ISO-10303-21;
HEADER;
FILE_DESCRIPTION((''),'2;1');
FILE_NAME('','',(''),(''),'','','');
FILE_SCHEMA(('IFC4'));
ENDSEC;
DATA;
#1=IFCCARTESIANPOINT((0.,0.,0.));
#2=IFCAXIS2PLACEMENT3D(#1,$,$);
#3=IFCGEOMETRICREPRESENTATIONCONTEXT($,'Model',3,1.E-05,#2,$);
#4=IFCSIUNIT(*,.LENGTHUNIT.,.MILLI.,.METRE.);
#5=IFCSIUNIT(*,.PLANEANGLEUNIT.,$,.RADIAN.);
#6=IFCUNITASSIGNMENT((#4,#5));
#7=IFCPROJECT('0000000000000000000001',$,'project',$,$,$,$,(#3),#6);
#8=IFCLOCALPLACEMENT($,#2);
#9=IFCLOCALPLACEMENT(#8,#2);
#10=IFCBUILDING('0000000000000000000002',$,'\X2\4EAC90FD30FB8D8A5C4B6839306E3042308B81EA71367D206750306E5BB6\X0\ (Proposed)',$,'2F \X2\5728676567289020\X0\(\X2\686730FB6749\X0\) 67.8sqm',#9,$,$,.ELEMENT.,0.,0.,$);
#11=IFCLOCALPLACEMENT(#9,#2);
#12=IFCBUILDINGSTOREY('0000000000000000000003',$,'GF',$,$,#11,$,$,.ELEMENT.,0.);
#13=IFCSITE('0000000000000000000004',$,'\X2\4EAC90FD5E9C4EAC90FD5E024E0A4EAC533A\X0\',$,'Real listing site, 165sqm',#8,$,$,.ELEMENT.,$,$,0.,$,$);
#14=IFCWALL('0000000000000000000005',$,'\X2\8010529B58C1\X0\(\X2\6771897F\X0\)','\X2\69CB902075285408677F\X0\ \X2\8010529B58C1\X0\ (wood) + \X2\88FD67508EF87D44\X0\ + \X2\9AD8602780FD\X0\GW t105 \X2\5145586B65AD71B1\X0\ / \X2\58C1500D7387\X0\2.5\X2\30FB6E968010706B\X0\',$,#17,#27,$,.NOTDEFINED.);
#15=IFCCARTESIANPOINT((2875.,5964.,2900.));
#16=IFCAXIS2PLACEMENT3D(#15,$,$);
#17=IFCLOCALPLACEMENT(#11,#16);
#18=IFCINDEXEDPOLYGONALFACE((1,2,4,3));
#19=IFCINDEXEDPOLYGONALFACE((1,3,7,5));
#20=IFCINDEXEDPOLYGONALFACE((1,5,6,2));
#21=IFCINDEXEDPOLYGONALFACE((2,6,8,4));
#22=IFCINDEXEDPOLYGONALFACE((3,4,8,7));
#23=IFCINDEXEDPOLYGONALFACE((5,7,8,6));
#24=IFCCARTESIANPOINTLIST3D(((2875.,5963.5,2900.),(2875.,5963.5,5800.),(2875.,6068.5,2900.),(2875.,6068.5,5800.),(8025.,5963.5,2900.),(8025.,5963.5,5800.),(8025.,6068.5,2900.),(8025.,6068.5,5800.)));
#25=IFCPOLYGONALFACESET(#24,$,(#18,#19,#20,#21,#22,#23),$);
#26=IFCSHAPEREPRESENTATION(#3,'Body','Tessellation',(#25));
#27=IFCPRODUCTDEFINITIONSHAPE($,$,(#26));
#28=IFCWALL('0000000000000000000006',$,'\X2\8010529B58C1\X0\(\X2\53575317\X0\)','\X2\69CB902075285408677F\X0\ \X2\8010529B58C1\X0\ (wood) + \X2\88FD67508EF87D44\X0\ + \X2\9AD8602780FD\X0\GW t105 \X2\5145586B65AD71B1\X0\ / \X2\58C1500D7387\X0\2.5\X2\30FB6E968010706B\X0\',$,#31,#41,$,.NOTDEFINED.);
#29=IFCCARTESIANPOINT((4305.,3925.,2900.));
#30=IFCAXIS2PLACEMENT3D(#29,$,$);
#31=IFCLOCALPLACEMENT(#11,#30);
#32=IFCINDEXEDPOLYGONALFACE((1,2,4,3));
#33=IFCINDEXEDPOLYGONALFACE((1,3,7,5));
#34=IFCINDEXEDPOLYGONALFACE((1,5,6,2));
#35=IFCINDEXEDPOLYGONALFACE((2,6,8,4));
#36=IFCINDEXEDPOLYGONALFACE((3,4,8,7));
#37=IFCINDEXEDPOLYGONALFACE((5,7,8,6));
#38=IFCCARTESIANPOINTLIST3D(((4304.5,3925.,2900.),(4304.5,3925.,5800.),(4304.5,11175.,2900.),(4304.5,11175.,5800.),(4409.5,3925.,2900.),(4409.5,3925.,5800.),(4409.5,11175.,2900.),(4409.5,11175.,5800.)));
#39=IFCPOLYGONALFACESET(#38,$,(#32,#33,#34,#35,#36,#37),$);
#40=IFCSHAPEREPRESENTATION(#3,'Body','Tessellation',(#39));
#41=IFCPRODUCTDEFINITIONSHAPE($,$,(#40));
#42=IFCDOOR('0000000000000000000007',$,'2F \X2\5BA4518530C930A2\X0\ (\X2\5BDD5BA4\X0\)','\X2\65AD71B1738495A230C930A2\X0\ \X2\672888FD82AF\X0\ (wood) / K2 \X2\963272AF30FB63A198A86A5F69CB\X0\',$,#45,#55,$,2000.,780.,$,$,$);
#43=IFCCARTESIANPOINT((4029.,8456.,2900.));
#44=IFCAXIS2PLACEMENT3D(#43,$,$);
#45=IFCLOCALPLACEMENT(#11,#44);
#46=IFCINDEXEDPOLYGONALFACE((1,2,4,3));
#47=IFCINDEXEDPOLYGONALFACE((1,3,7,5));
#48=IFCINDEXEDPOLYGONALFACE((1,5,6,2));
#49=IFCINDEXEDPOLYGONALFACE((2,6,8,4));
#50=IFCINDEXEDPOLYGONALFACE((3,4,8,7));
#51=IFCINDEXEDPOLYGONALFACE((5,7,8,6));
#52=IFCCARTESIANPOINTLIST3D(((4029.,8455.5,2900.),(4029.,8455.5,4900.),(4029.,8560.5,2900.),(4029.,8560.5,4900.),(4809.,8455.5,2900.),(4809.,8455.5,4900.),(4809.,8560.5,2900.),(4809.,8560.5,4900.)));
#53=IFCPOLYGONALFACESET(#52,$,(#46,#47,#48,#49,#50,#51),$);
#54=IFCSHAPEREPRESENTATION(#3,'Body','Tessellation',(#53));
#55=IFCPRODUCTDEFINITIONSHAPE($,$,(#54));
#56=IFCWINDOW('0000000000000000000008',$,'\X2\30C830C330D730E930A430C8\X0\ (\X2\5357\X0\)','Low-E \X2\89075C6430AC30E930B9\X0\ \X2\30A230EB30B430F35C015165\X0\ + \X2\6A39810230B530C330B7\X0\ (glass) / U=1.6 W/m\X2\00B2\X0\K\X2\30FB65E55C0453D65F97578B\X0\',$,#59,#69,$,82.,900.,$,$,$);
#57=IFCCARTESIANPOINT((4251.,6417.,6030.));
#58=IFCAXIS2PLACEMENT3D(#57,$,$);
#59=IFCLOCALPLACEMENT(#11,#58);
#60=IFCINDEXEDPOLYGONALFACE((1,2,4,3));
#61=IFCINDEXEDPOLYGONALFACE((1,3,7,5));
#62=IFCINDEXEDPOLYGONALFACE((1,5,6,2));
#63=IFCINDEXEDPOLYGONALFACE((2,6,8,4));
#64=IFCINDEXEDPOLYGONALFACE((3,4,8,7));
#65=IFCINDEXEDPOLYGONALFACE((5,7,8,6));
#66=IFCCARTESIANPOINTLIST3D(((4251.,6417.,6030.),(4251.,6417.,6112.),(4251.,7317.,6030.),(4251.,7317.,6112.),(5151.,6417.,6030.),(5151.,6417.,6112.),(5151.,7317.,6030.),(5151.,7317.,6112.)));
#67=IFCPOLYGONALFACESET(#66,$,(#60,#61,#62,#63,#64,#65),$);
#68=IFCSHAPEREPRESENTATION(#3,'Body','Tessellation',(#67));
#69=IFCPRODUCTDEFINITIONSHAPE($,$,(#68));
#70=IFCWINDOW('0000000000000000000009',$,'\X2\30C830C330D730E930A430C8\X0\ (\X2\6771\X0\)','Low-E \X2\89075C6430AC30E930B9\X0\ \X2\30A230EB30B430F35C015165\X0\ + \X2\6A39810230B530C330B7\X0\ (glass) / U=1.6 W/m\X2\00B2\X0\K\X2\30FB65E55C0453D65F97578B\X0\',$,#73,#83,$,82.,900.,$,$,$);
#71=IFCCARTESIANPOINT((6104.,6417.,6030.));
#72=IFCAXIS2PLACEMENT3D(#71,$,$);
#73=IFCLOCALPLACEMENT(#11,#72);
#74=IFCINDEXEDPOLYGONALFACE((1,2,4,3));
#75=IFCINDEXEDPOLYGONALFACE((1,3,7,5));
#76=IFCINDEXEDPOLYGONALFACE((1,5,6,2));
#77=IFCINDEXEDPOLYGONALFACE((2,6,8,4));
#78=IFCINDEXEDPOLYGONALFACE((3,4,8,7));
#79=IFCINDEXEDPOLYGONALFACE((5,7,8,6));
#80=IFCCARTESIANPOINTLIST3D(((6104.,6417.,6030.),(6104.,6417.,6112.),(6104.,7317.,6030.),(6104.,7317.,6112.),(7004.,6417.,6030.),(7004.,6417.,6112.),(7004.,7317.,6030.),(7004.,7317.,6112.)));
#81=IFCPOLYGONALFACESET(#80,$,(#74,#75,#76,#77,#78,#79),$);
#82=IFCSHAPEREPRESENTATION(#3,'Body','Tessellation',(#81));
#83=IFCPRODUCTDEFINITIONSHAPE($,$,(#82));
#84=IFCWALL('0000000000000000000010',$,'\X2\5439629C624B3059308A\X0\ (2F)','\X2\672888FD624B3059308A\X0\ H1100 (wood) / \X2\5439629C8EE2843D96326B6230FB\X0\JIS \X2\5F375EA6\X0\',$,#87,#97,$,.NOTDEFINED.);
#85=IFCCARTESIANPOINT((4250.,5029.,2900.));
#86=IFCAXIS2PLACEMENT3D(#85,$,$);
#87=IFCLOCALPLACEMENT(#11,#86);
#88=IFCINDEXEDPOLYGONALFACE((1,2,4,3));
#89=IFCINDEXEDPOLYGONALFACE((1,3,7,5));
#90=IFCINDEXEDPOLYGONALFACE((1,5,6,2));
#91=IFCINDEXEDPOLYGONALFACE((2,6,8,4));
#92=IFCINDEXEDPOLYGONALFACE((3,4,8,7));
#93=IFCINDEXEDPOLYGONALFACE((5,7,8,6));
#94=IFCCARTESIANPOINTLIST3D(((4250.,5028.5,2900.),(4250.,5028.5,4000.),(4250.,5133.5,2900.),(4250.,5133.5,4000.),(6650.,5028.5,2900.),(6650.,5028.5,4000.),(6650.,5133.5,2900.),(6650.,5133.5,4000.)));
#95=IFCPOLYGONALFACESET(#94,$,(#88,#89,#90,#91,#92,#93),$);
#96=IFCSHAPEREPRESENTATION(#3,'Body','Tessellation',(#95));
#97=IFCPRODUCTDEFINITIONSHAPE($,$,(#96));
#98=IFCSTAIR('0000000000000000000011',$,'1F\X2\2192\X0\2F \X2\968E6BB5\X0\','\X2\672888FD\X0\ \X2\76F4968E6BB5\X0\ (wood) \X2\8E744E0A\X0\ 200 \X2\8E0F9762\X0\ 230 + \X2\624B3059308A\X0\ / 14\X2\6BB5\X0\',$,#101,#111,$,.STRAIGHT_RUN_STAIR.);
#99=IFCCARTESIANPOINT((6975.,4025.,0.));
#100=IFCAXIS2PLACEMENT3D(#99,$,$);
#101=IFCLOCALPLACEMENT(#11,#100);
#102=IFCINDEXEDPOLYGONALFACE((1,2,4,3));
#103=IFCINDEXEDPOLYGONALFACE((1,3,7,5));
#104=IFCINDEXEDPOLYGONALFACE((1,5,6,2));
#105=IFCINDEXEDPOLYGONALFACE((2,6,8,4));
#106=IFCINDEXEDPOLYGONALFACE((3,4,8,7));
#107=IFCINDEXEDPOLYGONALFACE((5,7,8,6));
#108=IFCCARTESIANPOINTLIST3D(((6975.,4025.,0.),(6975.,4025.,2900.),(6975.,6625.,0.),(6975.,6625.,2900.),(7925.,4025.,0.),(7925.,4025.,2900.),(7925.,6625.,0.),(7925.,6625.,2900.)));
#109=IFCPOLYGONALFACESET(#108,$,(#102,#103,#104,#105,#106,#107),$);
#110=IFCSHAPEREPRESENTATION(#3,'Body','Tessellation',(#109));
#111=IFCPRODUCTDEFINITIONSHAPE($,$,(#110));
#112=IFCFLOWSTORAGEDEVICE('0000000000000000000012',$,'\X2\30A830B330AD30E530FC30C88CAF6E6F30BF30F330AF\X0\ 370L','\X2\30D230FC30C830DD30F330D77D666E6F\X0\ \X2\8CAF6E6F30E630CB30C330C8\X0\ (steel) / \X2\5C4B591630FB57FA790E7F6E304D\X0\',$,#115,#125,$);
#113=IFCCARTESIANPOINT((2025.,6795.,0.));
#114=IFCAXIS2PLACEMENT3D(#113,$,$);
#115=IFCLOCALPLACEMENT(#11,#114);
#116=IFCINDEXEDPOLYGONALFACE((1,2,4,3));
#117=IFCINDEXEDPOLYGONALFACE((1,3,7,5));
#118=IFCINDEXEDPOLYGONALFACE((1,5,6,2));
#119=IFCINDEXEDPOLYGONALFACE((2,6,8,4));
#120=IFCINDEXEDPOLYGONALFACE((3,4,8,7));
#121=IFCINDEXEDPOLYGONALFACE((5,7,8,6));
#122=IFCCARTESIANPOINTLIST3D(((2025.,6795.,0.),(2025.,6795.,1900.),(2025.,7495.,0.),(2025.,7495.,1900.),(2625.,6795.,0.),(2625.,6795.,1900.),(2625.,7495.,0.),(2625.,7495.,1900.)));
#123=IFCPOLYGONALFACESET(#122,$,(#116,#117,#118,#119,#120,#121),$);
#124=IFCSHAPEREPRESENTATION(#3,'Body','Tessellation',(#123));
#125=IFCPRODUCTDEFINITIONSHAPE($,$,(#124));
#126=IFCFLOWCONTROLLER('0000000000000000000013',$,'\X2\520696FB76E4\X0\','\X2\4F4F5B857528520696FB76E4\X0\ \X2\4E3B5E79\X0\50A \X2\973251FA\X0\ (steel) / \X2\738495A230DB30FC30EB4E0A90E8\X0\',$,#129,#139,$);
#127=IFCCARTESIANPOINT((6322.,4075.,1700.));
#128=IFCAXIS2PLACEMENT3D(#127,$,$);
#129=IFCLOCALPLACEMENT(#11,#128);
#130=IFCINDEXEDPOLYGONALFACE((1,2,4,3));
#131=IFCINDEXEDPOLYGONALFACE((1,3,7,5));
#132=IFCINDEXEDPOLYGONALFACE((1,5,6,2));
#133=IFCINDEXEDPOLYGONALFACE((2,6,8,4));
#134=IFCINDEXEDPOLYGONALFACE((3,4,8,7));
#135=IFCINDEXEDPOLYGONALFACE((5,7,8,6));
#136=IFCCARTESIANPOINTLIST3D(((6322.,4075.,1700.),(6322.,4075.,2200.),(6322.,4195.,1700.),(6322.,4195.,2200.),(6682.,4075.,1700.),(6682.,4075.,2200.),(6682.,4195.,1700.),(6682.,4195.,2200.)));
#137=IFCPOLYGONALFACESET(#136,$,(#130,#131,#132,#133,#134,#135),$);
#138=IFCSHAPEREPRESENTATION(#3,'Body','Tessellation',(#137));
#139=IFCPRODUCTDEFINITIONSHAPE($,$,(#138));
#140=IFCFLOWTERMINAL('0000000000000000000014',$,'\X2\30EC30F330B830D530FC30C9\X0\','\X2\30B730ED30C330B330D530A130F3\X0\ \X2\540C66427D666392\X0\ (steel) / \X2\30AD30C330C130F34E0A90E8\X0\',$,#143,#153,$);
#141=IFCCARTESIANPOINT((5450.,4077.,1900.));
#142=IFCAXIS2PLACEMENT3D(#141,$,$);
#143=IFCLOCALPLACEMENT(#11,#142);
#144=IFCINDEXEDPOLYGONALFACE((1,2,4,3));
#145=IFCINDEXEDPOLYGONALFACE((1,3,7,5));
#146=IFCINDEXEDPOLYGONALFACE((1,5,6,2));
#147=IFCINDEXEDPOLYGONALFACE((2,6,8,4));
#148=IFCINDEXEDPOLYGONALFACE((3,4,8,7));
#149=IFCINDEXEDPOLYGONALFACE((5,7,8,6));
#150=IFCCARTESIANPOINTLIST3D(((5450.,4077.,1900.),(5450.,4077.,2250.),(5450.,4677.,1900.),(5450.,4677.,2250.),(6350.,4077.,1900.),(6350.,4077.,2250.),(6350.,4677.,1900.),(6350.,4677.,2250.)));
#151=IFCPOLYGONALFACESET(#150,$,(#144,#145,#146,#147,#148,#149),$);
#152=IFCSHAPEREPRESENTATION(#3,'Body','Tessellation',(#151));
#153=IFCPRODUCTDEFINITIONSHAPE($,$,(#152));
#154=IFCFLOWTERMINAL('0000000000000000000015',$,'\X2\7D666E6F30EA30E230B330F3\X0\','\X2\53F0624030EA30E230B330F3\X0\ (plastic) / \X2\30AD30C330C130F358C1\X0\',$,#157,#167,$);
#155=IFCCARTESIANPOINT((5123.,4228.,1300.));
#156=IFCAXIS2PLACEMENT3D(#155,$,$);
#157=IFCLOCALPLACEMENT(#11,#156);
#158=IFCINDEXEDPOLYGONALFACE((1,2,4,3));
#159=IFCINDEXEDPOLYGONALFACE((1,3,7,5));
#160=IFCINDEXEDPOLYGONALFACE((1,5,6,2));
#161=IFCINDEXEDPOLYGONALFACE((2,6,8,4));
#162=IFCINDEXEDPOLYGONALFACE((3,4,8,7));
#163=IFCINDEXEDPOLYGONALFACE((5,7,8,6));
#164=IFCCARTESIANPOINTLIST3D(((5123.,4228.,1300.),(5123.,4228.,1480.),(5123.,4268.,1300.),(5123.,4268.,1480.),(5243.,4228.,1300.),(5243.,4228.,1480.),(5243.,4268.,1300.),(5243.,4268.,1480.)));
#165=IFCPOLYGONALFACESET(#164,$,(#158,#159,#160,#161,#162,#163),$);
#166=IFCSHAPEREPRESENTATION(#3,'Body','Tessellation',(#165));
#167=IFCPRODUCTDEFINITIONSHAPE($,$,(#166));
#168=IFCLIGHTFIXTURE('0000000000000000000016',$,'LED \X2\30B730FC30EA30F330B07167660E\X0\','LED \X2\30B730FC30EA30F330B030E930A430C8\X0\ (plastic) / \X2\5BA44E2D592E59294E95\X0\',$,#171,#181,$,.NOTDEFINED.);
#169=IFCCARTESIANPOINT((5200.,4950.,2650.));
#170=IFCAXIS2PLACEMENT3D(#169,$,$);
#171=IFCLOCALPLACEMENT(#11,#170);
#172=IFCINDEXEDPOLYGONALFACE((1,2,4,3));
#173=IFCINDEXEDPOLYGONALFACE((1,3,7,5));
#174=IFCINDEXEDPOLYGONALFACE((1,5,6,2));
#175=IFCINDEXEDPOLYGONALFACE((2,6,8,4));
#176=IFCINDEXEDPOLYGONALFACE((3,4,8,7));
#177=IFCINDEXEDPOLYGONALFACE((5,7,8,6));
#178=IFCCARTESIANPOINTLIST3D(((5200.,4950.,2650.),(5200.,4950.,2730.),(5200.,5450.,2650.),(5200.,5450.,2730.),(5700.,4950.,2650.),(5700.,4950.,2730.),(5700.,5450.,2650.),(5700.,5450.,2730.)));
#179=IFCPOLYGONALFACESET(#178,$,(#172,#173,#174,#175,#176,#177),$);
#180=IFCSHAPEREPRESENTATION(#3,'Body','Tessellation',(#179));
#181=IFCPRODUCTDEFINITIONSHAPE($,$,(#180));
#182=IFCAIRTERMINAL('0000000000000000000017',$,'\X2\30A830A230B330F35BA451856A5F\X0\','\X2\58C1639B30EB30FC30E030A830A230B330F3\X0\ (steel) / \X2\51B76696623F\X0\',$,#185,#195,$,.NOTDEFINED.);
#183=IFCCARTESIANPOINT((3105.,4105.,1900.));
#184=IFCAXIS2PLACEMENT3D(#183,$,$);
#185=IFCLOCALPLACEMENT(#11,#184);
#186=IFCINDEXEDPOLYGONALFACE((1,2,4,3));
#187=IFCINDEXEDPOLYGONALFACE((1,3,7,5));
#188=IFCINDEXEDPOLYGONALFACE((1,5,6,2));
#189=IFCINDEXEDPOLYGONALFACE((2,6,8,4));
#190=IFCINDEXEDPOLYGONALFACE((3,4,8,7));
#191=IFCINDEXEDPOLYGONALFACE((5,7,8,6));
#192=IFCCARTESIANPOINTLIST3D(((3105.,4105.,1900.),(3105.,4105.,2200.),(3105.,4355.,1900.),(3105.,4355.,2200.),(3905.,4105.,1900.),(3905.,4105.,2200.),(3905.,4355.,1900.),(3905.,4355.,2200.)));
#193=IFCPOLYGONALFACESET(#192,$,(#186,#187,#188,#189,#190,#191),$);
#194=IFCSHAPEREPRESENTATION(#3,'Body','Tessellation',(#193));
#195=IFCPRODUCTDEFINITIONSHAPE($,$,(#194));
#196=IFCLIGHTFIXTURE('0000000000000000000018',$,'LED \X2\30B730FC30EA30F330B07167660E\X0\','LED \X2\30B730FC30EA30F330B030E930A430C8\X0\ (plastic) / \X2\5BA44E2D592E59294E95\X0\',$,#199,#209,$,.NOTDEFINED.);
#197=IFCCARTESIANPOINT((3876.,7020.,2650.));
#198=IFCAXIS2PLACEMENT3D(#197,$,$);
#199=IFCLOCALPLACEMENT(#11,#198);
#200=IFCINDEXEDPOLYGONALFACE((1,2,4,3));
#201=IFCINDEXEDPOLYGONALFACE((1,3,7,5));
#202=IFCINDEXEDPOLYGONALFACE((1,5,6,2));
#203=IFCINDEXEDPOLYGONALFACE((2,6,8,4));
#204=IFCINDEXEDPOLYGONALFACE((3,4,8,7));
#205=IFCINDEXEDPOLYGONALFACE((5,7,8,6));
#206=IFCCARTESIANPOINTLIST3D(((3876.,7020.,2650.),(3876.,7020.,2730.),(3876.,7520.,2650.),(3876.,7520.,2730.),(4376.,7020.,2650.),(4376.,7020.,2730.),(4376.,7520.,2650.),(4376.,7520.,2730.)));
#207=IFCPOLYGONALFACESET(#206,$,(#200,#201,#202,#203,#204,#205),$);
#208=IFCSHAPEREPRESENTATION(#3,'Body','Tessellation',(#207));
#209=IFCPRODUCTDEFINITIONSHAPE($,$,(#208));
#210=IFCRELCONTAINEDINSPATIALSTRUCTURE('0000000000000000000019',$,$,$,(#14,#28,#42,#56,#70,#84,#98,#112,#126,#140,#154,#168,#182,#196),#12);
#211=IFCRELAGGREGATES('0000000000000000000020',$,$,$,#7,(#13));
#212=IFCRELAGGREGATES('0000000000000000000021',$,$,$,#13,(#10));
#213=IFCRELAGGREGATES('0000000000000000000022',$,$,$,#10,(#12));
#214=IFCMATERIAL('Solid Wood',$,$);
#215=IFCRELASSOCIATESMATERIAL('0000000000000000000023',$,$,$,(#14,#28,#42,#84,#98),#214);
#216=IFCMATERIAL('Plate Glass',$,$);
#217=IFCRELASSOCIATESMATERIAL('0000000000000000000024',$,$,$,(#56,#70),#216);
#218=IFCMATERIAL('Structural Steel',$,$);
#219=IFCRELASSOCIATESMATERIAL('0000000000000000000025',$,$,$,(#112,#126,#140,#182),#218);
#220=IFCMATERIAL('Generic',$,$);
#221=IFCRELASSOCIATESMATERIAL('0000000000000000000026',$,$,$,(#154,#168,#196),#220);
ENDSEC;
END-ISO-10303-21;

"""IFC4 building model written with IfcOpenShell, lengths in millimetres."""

from ifc_helpers import new_model, si_unit, frame, frame_2d, origin, place, context, project, spatial, rectangle, extrude, material, element, fill, save


model = new_model("IFC4")

# Units and contexts
model_context = context("Model", 3, precision=1e-05, world=origin())
ifc_project = project(units=[si_unit("LENGTHUNIT", "METRE", prefix="MILLI"), si_unit("PLANEANGLEUNIT", "RADIAN")], contexts=[model_context])

# Site, building, storey
site_placement = place(None, origin())
site = spatial("IfcSite", under=ifc_project, at=site_placement, Name="京都府京都市上京区", ObjectType="Real listing site, 165sqm", CompositionType="ELEMENT", RefElevation=0.0)
building_placement = place(site_placement, origin())
building = spatial("IfcBuilding", under=site, at=building_placement, Name="京都・越屋根のある自然素材の家 (Proposed)", ObjectType="2F 在来木造(桧・杉) 67.8sqm", CompositionType="ELEMENT", ElevationOfRefHeight=0.0, ElevationOfTerrain=0.0)
storey_placement = place(building_placement, origin())
storey = spatial("IfcBuildingStorey", under=building, at=storey_placement, Name="GF", CompositionType="ELEMENT", Elevation=0.0)

# Shared definitions
ifc_material_1 = material(Name="Solid Wood")

# Wall
wall_1_placement = place(storey_placement, frame((2875.0, 5964.0, 2900.0)))
element("IfcWall", 1, at=wall_1_placement, inside=storey, material=ifc_material_1, Name="耐力壁(東西)", Description="構造用合板 耐力壁 (wood) + 製材軸組 + 高性能GW t105 充填断熱 / 壁倍率2.5・準耐火", PredefinedType="NOTDEFINED", context=model_context, shape_type="SweptSolid", body=[
    extrude(rectangle(XDim=5150.0, YDim=105.0, at=frame_2d((2575.0, 52.0))), frame((2875.0, 5964.0, 2900.0)), (0.0, 0.0, 1.0), 2900.0),
])

# Wall, opening, door
wall_2_placement = place(storey_placement, frame((4305.0, 3925.0, 2900.0)))
wall_2 = element("IfcWall", 2, at=wall_2_placement, inside=storey, material=ifc_material_1, Name="耐力壁(南北)", Description="構造用合板 耐力壁 (wood) + 製材軸組 + 高性能GW t105 充填断熱 / 壁倍率2.5・準耐火", PredefinedType="NOTDEFINED", context=model_context, shape_type="SweptSolid", body=[
    extrude(rectangle(XDim=105.0, YDim=7250.0, at=frame_2d((52.0, 3625.0))), frame((4305.0, 3925.0, 2900.0)), (0.0, 0.0, 1.0), 2900.0),
])
opening_placement = place(storey_placement, frame((4029.0, 8456.0, 2900.0)))
opening = element("IfcOpeningElement", 3, at=opening_placement, cuts=wall_2, PredefinedType="NOTDEFINED", context=model_context, shape_type="SweptSolid", body=[
    extrude(rectangle(XDim=780.0, YDim=105.0, at=frame_2d((390.0, 52.0))), frame((4029.0, 8456.0, 2900.0)), (0.0, 0.0, 1.0), 2000.0),
])
door_placement = place(storey_placement, frame((4029.0, 8456.0, 2900.0)))
door = element("IfcDoor", 4, at=door_placement, inside=storey, material=ifc_material_1, Name="2F 室内ドア (寝室)", Description="断熱玄関ドア 木製芯 (wood) / K2 防犯・採風機構", OverallHeight=2000.0, OverallWidth=780.0, context=model_context, shape_type="SweptSolid", body=[
    extrude(rectangle(XDim=780.0, YDim=105.0, at=frame_2d((390.0, 52.0))), frame((4029.0, 8456.0, 2900.0)), (0.0, 0.0, 1.0), 2000.0),
])
fill(opening, door)

# Windows
ifc_material_2 = material(Name="Plate Glass")
window_1_placement = place(storey_placement, frame((4251.0, 6417.0, 6030.0)))
element("IfcWindow", 5, at=window_1_placement, inside=storey, material=ifc_material_2, Name="トップライト (南)", Description="Low-E 複層ガラス アルゴン封入 + 樹脂サッシ (glass) / U=1.6 W/m²K・日射取得型", OverallHeight=82.0, OverallWidth=900.0, context=model_context, shape_type="SweptSolid", body=[
    extrude(rectangle(XDim=900.0, YDim=900.0, at=frame_2d((450.0, 450.0))), frame((4251.0, 6417.0, 6030.0)), (0.0, 0.0, 1.0), 82.0),
])
window_2_placement = place(storey_placement, frame((6104.0, 6417.0, 6030.0)))
element("IfcWindow", 6, at=window_2_placement, inside=storey, material=ifc_material_2, Name="トップライト (東)", Description="Low-E 複層ガラス アルゴン封入 + 樹脂サッシ (glass) / U=1.6 W/m²K・日射取得型", OverallHeight=82.0, OverallWidth=900.0, context=model_context, shape_type="SweptSolid", body=[
    extrude(rectangle(XDim=900.0, YDim=900.0, at=frame_2d((450.0, 450.0))), frame((6104.0, 6417.0, 6030.0)), (0.0, 0.0, 1.0), 82.0),
])

# Wall
wall_3_placement = place(storey_placement, frame((4250.0, 5029.0, 2900.0)))
element("IfcWall", 7, at=wall_3_placement, inside=storey, material=ifc_material_1, Name="吹抜手すり (2F)", Description="木製手すり H1100 (wood) / 吹抜転落防止・JIS 強度", PredefinedType="NOTDEFINED", context=model_context, shape_type="SweptSolid", body=[
    extrude(rectangle(XDim=2400.0, YDim=105.0, at=frame_2d((1200.0, 52.0))), frame((4250.0, 5029.0, 2900.0)), (0.0, 0.0, 1.0), 1100.0),
])

# Stair
stair_placement = place(storey_placement, frame((6975.0, 4025.0, 0.0)))
element("IfcStair", 8, at=stair_placement, inside=storey, material=ifc_material_1, Name="1F→2F 階段", Description="木製 直階段 (wood) 蹴上 200 踏面 230 + 手すり / 14段", PredefinedType="STRAIGHT_RUN_STAIR", context=model_context, shape_type="SweptSolid", body=[
    extrude(rectangle(XDim=950.0, YDim=2600.0, at=frame_2d((475.0, 1300.0))), frame((6975.0, 4025.0, 0.0)), (0.0, 0.0, 1.0), 2900.0),
])

# Flow storage device
ifc_material_3 = material(Name="Structural Steel")
flow_storage_device_placement = place(storey_placement, frame((2025.0, 6795.0, 0.0)))
element("IfcFlowStorageDevice", 9, at=flow_storage_device_placement, inside=storey, material=ifc_material_3, Name="エコキュート貯湯タンク 370L", Description="ヒートポンプ給湯 貯湯ユニット (steel) / 屋外・基礎置き", context=model_context, shape_type="SweptSolid", body=[
    extrude(rectangle(XDim=600.0, YDim=700.0, at=frame_2d((300.0, 350.0))), frame((2025.0, 6795.0, 0.0)), (0.0, 0.0, 1.0), 1900.0),
])

# Flow controller
flow_controller_placement = place(storey_placement, frame((6322.0, 4075.0, 1700.0)))
element("IfcFlowController", 10, at=flow_controller_placement, inside=storey, material=ifc_material_3, Name="分電盤", Description="住宅用分電盤 主幹50A 露出 (steel) / 玄関ホール上部", context=model_context, shape_type="SweptSolid", body=[
    extrude(rectangle(XDim=360.0, YDim=120.0, at=frame_2d((180.0, 60.0))), frame((6322.0, 4075.0, 1700.0)), (0.0, 0.0, 1.0), 500.0),
])

# Flow terminals
flow_terminal_1_placement = place(storey_placement, frame((5450.0, 4077.0, 1900.0)))
element("IfcFlowTerminal", 11, at=flow_terminal_1_placement, inside=storey, material=ifc_material_3, Name="レンジフード", Description="シロッコファン 同時給排 (steel) / キッチン上部", context=model_context, shape_type="SweptSolid", body=[
    extrude(rectangle(XDim=900.0, YDim=600.0, at=frame_2d((450.0, 300.0))), frame((5450.0, 4077.0, 1900.0)), (0.0, 0.0, 1.0), 350.0),
])
ifc_material_4 = material(Name="Generic")
flow_terminal_2_placement = place(storey_placement, frame((5123.0, 4228.0, 1300.0)))
element("IfcFlowTerminal", 12, at=flow_terminal_2_placement, inside=storey, material=ifc_material_4, Name="給湯リモコン", Description="台所リモコン (plastic) / キッチン壁", context=model_context, shape_type="SweptSolid", body=[
    extrude(rectangle(XDim=120.0, YDim=40.0, at=frame_2d((60.0, 20.0))), frame((5123.0, 4228.0, 1300.0)), (0.0, 0.0, 1.0), 180.0),
])

# Light fixture
light_fixture_1_placement = place(storey_placement, frame((5200.0, 4950.0, 2650.0)))
element("IfcLightFixture", 13, at=light_fixture_1_placement, inside=storey, material=ifc_material_4, Name="LED シーリング照明", Description="LED シーリングライト (plastic) / 室中央天井", PredefinedType="NOTDEFINED", context=model_context, shape_type="SweptSolid", body=[
    extrude(rectangle(XDim=500.0, YDim=500.0, at=frame_2d((250.0, 250.0))), frame((5200.0, 4950.0, 2650.0)), (0.0, 0.0, 1.0), 80.0),
])

# Air terminal
air_terminal_1_placement = place(storey_placement, frame((3105.0, 4105.0, 1900.0)))
element("IfcAirTerminal", 14, at=air_terminal_1_placement, inside=storey, material=ifc_material_3, Name="エアコン室内機", Description="壁掛ルームエアコン (steel) / 冷暖房", PredefinedType="NOTDEFINED", context=model_context, shape_type="SweptSolid", body=[
    extrude(rectangle(XDim=800.0, YDim=250.0, at=frame_2d((400.0, 125.0))), frame((3105.0, 4105.0, 1900.0)), (0.0, 0.0, 1.0), 300.0),
])

# Light fixture
light_fixture_2_placement = place(storey_placement, frame((3876.0, 7020.0, 2650.0)))
element("IfcLightFixture", 15, at=light_fixture_2_placement, inside=storey, material=ifc_material_4, Name="LED シーリング照明", Description="LED シーリングライト (plastic) / 室中央天井", PredefinedType="NOTDEFINED", context=model_context, shape_type="SweptSolid", body=[
    extrude(rectangle(XDim=500.0, YDim=500.0, at=frame_2d((250.0, 250.0))), frame((3876.0, 7020.0, 2650.0)), (0.0, 0.0, 1.0), 80.0),
])

save(model, "model.ifc")
